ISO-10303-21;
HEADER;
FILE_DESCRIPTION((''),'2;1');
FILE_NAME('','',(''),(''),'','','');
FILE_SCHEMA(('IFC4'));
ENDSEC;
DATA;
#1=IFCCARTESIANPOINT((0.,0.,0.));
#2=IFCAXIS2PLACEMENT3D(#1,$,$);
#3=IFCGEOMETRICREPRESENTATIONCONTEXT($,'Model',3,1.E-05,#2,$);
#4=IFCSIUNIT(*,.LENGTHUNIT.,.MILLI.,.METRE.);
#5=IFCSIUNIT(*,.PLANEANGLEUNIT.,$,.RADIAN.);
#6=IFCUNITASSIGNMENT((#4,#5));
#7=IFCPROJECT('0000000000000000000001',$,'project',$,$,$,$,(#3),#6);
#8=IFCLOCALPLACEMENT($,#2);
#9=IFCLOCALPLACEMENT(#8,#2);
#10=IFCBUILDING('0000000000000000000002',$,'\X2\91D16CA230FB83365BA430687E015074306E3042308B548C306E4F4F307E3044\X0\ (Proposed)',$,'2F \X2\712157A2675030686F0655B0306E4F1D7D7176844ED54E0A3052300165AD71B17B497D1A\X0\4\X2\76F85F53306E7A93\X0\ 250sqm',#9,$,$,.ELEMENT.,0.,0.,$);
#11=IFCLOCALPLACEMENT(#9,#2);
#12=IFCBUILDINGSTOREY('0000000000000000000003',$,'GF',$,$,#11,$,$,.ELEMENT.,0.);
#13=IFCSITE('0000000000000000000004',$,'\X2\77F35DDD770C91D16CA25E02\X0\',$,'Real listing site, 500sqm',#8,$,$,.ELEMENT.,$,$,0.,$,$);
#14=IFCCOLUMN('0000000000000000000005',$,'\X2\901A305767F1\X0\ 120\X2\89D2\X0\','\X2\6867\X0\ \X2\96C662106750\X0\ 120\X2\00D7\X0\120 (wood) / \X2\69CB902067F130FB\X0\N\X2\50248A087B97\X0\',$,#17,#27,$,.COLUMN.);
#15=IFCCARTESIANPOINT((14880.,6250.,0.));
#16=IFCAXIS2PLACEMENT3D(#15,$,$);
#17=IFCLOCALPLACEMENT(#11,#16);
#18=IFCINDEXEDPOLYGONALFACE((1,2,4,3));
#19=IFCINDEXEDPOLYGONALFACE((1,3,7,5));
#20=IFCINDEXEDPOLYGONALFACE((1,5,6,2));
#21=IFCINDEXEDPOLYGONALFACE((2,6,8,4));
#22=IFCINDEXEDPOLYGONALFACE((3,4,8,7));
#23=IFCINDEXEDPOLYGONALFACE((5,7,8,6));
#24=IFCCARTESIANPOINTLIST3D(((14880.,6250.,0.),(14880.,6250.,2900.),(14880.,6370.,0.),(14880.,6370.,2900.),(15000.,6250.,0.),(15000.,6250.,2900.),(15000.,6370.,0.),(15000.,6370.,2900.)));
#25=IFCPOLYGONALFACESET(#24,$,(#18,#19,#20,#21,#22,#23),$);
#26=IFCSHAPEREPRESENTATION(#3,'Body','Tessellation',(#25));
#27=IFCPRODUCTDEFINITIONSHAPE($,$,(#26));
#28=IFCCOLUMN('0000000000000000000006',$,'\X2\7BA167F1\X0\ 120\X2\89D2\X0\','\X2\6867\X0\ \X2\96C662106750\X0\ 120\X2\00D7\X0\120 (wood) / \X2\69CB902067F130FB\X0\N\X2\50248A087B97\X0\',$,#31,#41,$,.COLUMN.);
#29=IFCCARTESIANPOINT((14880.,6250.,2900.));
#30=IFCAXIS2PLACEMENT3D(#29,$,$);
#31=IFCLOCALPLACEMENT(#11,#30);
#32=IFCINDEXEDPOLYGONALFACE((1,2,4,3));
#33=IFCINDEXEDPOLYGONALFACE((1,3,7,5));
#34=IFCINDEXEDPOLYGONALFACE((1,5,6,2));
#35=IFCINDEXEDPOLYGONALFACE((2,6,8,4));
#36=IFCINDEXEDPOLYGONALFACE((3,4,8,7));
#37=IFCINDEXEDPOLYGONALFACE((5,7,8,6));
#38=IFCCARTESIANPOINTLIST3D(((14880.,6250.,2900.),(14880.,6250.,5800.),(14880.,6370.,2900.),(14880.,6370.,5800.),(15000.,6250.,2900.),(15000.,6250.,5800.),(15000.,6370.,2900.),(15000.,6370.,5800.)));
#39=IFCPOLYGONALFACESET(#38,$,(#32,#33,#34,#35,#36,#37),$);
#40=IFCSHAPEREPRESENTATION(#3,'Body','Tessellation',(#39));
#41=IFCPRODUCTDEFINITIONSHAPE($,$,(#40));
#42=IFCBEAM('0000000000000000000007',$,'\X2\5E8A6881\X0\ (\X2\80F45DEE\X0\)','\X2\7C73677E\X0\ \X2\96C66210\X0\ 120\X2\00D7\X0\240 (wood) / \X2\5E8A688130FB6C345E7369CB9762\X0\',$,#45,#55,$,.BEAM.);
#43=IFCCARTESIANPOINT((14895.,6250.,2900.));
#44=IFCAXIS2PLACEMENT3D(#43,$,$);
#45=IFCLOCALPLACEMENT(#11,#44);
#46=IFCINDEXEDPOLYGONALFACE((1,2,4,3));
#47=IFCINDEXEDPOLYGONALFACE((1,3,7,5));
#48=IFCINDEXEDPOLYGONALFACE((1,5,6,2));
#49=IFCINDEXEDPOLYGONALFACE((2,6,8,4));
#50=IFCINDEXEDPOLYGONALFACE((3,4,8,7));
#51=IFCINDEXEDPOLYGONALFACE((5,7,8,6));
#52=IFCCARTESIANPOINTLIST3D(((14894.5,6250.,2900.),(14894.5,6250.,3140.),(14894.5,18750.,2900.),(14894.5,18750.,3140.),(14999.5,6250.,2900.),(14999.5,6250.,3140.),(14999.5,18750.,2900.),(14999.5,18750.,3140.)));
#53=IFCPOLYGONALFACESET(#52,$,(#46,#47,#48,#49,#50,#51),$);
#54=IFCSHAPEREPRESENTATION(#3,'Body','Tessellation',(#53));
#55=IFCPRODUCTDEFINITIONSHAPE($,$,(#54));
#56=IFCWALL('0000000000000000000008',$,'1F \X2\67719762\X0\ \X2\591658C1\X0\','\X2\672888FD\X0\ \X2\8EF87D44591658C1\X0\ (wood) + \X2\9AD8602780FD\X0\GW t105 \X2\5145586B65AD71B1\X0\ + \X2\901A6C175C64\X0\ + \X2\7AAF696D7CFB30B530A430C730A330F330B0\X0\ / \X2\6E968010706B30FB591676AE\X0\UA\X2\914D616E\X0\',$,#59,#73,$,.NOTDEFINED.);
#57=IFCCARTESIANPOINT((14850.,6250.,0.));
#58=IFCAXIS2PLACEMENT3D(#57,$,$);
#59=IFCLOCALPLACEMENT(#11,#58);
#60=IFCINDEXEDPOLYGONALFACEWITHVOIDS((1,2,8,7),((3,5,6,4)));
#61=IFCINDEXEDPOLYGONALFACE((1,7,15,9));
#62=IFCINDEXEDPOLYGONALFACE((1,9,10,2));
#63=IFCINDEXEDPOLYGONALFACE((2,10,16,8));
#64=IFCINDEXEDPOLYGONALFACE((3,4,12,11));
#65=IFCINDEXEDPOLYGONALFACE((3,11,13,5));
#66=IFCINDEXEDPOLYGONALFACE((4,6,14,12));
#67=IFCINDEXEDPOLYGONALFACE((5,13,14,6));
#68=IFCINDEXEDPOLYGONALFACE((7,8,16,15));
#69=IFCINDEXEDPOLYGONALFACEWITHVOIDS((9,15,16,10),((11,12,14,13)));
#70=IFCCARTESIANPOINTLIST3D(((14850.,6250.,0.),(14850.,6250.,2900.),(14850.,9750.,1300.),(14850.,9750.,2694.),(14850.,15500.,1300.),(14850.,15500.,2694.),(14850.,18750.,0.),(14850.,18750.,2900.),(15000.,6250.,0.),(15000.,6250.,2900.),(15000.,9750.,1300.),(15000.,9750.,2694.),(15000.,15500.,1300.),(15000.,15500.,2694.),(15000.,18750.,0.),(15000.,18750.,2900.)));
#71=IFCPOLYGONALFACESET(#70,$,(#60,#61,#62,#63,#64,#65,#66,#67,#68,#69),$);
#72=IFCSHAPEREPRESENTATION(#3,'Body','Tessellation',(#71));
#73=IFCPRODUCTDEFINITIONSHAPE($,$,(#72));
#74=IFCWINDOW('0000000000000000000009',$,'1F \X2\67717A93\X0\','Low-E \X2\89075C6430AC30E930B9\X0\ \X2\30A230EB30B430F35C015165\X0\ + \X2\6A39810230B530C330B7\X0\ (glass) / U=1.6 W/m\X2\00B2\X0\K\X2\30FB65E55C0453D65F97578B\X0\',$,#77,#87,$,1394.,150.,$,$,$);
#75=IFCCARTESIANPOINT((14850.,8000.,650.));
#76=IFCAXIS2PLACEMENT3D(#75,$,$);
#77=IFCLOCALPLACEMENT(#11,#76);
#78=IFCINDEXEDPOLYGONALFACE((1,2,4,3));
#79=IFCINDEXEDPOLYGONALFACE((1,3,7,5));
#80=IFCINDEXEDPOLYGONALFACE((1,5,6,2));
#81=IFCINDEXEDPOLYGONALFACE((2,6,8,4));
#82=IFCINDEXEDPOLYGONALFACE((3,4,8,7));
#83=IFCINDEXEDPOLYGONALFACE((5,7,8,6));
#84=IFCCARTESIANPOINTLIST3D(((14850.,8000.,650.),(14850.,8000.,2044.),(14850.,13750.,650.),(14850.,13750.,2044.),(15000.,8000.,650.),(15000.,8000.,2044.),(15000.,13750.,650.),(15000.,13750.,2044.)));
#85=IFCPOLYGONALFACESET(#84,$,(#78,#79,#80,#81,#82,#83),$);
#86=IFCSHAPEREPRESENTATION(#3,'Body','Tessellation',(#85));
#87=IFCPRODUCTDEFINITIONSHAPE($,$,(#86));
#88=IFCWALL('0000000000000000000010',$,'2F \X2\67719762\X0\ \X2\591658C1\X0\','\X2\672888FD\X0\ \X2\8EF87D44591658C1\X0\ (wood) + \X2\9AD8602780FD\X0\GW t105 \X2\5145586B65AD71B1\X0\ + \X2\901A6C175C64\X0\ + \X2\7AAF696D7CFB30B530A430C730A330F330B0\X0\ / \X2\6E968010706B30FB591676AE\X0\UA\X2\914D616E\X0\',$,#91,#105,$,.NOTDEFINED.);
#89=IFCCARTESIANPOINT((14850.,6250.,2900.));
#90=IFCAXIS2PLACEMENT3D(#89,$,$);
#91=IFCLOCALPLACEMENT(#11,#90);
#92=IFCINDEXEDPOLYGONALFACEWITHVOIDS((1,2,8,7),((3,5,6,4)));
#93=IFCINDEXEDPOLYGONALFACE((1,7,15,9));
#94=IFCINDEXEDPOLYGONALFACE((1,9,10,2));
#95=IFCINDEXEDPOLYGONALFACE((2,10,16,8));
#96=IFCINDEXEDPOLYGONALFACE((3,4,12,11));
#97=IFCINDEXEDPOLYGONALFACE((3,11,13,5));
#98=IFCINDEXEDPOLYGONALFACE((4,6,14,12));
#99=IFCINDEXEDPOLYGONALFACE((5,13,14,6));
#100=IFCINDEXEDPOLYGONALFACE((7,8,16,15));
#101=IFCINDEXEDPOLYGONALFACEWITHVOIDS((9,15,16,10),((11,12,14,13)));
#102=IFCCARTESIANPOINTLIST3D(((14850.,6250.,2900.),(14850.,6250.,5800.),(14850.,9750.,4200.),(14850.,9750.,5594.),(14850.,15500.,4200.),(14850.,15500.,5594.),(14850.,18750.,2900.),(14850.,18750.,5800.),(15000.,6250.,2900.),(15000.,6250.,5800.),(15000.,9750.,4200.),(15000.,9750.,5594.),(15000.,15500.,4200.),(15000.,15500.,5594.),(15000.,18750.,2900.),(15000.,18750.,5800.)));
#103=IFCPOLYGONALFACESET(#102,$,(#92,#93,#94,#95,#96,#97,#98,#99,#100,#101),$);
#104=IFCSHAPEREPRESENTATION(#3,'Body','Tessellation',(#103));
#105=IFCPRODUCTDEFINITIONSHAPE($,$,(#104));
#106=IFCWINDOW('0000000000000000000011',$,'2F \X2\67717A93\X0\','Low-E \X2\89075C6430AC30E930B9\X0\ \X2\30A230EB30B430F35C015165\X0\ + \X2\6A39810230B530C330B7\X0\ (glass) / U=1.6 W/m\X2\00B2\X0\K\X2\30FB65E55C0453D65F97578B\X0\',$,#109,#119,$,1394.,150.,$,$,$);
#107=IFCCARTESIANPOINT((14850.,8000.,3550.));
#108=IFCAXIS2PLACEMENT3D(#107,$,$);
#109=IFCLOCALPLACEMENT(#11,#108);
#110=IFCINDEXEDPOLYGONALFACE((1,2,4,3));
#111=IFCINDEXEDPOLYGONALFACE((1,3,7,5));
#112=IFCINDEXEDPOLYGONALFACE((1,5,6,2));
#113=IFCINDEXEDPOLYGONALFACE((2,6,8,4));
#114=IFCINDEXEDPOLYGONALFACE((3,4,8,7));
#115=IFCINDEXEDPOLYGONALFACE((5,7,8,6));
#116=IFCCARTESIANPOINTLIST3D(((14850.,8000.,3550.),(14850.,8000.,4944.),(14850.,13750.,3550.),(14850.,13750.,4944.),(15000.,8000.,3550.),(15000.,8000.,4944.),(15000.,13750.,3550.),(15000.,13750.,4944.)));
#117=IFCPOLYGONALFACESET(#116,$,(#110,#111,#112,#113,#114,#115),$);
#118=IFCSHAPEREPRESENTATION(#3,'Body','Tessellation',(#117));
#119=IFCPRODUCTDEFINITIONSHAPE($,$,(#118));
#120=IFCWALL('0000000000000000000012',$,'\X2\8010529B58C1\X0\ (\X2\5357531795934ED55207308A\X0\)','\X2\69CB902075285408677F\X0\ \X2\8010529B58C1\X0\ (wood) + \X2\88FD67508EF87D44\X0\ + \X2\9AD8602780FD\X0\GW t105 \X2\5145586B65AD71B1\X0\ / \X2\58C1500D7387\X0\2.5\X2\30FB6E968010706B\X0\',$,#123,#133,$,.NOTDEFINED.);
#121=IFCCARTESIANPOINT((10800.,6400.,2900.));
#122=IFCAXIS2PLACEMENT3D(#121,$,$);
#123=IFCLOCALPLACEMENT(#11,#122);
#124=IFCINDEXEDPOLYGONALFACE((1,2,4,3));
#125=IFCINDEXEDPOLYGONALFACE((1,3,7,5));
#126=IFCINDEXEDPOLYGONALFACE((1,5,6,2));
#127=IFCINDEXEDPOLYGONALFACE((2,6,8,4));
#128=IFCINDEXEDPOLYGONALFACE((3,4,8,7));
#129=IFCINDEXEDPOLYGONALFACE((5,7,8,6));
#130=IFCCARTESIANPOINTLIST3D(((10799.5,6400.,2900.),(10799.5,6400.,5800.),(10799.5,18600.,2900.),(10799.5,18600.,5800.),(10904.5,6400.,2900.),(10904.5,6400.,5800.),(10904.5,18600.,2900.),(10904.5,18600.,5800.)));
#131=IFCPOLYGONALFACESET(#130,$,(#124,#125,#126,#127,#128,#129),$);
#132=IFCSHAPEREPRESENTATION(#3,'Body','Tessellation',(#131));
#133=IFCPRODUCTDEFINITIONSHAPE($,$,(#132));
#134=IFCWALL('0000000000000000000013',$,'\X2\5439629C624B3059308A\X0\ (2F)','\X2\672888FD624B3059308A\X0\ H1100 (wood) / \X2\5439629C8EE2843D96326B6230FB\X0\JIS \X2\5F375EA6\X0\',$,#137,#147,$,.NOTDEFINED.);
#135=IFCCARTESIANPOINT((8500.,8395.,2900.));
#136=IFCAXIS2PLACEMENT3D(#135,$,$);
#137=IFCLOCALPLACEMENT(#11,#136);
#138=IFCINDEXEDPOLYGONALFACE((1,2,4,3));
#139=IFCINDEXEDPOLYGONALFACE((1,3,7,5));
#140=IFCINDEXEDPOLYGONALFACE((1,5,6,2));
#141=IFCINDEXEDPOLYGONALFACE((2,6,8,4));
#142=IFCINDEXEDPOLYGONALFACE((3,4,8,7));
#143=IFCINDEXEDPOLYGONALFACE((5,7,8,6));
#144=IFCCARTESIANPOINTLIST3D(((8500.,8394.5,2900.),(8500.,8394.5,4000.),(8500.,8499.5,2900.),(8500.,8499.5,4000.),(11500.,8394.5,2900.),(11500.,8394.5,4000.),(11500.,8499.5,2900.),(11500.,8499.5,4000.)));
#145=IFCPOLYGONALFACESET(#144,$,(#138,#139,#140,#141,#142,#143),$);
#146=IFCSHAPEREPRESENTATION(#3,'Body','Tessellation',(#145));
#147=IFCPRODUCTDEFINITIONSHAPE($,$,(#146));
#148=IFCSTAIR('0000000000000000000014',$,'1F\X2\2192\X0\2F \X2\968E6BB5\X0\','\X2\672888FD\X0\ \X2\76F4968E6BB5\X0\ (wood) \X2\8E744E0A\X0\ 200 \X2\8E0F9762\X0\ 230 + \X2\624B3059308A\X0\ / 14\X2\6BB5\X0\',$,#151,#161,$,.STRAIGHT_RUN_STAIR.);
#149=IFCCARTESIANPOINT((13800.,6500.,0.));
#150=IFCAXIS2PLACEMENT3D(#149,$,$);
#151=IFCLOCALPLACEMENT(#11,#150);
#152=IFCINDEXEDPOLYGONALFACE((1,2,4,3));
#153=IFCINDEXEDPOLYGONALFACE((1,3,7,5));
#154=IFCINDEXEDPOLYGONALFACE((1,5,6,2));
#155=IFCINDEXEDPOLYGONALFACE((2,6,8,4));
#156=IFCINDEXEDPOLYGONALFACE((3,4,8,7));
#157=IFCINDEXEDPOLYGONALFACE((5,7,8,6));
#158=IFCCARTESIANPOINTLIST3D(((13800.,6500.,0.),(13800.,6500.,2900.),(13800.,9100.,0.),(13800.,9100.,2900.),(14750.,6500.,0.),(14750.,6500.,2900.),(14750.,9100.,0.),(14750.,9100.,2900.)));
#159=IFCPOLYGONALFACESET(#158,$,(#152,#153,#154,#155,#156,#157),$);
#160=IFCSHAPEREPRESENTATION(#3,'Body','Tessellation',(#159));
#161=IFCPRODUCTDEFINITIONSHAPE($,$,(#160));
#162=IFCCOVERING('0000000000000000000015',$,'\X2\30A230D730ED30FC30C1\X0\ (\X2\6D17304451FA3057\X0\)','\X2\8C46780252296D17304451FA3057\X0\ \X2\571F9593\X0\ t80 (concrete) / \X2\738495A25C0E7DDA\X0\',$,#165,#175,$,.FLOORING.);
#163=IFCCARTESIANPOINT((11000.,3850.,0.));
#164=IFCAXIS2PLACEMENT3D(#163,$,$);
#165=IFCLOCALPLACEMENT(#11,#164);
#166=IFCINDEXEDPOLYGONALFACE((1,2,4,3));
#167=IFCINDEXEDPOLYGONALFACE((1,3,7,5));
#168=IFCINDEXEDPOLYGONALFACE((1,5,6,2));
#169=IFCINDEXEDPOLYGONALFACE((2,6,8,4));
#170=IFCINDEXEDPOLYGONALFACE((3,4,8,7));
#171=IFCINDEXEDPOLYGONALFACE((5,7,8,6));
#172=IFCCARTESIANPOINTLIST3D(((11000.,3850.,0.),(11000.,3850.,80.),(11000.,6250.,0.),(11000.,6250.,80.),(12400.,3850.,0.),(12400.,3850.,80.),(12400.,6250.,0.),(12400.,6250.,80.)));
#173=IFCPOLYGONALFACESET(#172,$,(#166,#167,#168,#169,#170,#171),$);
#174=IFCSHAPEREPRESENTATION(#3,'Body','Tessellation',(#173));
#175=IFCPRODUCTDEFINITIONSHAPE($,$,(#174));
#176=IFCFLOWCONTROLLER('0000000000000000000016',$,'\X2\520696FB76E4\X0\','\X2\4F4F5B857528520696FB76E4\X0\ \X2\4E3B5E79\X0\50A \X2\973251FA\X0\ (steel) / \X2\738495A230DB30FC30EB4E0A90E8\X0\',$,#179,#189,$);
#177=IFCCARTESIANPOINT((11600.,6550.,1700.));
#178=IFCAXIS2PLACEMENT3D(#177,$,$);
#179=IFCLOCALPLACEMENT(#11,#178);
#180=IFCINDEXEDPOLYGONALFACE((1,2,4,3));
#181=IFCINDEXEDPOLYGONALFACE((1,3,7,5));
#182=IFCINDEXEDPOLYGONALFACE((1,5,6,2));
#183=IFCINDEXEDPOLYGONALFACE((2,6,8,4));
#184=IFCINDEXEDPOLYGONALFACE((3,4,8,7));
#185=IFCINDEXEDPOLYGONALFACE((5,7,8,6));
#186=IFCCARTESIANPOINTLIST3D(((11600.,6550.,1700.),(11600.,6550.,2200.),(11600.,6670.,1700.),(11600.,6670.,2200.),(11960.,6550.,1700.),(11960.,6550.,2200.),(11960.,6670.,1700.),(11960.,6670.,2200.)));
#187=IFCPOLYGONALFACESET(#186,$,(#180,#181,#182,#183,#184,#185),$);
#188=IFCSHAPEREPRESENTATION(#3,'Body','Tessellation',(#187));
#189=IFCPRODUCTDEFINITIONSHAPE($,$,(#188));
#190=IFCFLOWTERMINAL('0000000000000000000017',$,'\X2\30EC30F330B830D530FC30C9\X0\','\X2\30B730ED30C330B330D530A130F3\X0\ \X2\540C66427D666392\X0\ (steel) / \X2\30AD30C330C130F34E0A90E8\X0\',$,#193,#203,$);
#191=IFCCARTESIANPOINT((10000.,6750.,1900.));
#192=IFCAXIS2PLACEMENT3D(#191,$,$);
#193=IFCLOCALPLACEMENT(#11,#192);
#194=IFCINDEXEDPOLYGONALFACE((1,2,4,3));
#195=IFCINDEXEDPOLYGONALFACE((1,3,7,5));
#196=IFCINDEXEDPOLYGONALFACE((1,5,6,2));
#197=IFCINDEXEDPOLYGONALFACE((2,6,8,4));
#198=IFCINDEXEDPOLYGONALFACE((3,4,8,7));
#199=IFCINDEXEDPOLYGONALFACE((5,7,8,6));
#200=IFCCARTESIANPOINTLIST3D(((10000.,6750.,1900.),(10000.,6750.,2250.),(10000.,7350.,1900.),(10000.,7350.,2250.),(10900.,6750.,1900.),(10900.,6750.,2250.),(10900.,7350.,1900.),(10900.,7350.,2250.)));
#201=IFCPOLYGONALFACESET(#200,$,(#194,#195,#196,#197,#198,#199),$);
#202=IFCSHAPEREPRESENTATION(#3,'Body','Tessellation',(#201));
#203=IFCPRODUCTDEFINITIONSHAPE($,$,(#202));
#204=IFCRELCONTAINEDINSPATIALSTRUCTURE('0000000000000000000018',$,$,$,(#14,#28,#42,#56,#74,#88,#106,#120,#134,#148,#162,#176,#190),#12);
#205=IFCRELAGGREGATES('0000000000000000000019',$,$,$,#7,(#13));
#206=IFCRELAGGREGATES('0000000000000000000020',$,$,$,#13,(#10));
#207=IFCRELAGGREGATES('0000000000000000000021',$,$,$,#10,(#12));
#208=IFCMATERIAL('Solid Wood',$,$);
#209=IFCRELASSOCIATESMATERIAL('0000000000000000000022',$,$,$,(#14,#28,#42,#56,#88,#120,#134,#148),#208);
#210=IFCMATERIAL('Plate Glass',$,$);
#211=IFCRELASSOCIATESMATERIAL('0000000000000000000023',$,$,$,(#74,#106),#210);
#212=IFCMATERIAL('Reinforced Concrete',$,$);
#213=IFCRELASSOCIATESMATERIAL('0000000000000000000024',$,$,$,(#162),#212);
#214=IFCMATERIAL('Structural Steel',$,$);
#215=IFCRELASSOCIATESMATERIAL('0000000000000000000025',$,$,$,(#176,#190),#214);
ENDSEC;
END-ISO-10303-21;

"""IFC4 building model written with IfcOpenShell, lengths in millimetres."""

from ifc_helpers import new_model, si_unit, frame, frame_2d, origin, place, context, project, spatial, rectangle, extrude, material, element, fill, save


model = new_model("IFC4")

# Units and contexts
model_context = context("Model", 3, precision=1e-05, world=origin())
ifc_project = project(units=[si_unit("LENGTHUNIT", "METRE", prefix="MILLI"), si_unit("PLANEANGLEUNIT", "RADIAN")], contexts=[model_context])

# Site, building, storey
site_placement = place(None, origin())
site = spatial("IfcSite", under=ifc_project, at=site_placement, Name="石川県金沢市", ObjectType="Real listing site, 500sqm", CompositionType="ELEMENT", RefElevation=0.0)
building_placement = place(site_placement, origin())
building = spatial("IfcBuilding", under=site, at=building_placement, Name="金沢・茶室と縁側のある和の住まい (Proposed)", ObjectType="2F 無垢材と漆喰の伝統的仕上げ、断熱等級4相当の窓 250sqm", CompositionType="ELEMENT", ElevationOfRefHeight=0.0, ElevationOfTerrain=0.0)
storey_placement = place(building_placement, origin())
storey = spatial("IfcBuildingStorey", under=building, at=storey_placement, Name="GF", CompositionType="ELEMENT", Elevation=0.0)

# Columns
ifc_material_1 = material(Name="Solid Wood")
column_1_placement = place(storey_placement, frame((14880.0, 6250.0, 0.0)))
element("IfcColumn", 1, at=column_1_placement, inside=storey, material=ifc_material_1, Name="通し柱 120角", Description="桧 集成材 120×120 (wood) / 構造柱・N値計算", PredefinedType="COLUMN", context=model_context, shape_type="SweptSolid", body=[
    extrude(rectangle(XDim=120.0, YDim=120.0, at=frame_2d((60.0, 60.0))), frame((14880.0, 6250.0, 0.0)), (0.0, 0.0, 1.0), 2900.0),
])
column_2_placement = place(storey_placement, frame((14880.0, 6250.0, 2900.0)))
element("IfcColumn", 2, at=column_2_placement, inside=storey, material=ifc_material_1, Name="管柱 120角", Description="桧 集成材 120×120 (wood) / 構造柱・N値計算", PredefinedType="COLUMN", context=model_context, shape_type="SweptSolid", body=[
    extrude(rectangle(XDim=120.0, YDim=120.0, at=frame_2d((60.0, 60.0))), frame((14880.0, 6250.0, 2900.0)), (0.0, 0.0, 1.0), 2900.0),
])

# Beam
beam_1_placement = place(storey_placement, frame((14895.0, 6250.0, 2900.0)))
element("IfcBeam", 3, at=beam_1_placement, inside=storey, material=ifc_material_1, Name="床梁 (胴差)", Description="米松 集成 120×240 (wood) / 床梁・水平構面", PredefinedType="BEAM", context=model_context, shape_type="SweptSolid", body=[
    extrude(rectangle(XDim=105.0, YDim=12500.0, at=frame_2d((52.0, 6250.0))), frame((14895.0, 6250.0, 2900.0)), (0.0, 0.0, 1.0), 240.0),
])

# Wall, opening, window
wall_1_placement = place(storey_placement, frame((14850.0, 6250.0, 0.0)))
wall_1 = element("IfcWall", 4, at=wall_1_placement, inside=storey, material=ifc_material_1, Name="1F 東面 外壁", Description="木製 軸組外壁 (wood) + 高性能GW t105 充填断熱 + 通気層 + 窯業系サイディング / 準耐火・外皮UA配慮", PredefinedType="NOTDEFINED", context=model_context, shape_type="SweptSolid", body=[
    extrude(rectangle(XDim=150.0, YDim=12500.0, at=frame_2d((75.0, 6250.0))), frame((14850.0, 6250.0, 0.0)), (0.0, 0.0, 1.0), 2900.0),
])
opening_1_placement = place(storey_placement, frame((14850.0, 8000.0, 650.0)))
opening_1 = element("IfcOpeningElement", 5, at=opening_1_placement, cuts=wall_1, PredefinedType="NOTDEFINED", context=model_context, shape_type="SweptSolid", body=[
    extrude(rectangle(XDim=150.0, YDim=5750.0, at=frame_2d((75.0, 2875.0))), frame((14850.0, 8000.0, 650.0)), (0.0, 0.0, 1.0), 1394.0),
])
ifc_material_2 = material(Name="Plate Glass")
window_1_placement = place(storey_placement, frame((14850.0, 8000.0, 650.0)))
window_1 = element("IfcWindow", 6, at=window_1_placement, inside=storey, material=ifc_material_2, Name="1F 東窓", Description="Low-E 複層ガラス アルゴン封入 + 樹脂サッシ (glass) / U=1.6 W/m²K・日射取得型", OverallHeight=1394.0, OverallWidth=150.0, context=model_context, shape_type="SweptSolid", body=[
    extrude(rectangle(XDim=150.0, YDim=5750.0, at=frame_2d((75.0, 2875.0))), frame((14850.0, 8000.0, 650.0)), (0.0, 0.0, 1.0), 1394.0),
])
fill(opening_1, window_1)

# Wall, opening, window
wall_2_placement = place(storey_placement, frame((14850.0, 6250.0, 2900.0)))
wall_2 = element("IfcWall", 7, at=wall_2_placement, inside=storey, material=ifc_material_1, Name="2F 東面 外壁", Description="木製 軸組外壁 (wood) + 高性能GW t105 充填断熱 + 通気層 + 窯業系サイディング / 準耐火・外皮UA配慮", PredefinedType="NOTDEFINED", context=model_context, shape_type="SweptSolid", body=[
    extrude(rectangle(XDim=150.0, YDim=12500.0, at=frame_2d((75.0, 6250.0))), frame((14850.0, 6250.0, 2900.0)), (0.0, 0.0, 1.0), 2900.0),
])
opening_2_placement = place(storey_placement, frame((14850.0, 8000.0, 3550.0)))
opening_2 = element("IfcOpeningElement", 8, at=opening_2_placement, cuts=wall_2, PredefinedType="NOTDEFINED", context=model_context, shape_type="SweptSolid", body=[
    extrude(rectangle(XDim=150.0, YDim=5750.0, at=frame_2d((75.0, 2875.0))), frame((14850.0, 8000.0, 3550.0)), (0.0, 0.0, 1.0), 1394.0),
])
window_2_placement = place(storey_placement, frame((14850.0, 8000.0, 3550.0)))
window_2 = element("IfcWindow", 9, at=window_2_placement, inside=storey, material=ifc_material_2, Name="2F 東窓", Description="Low-E 複層ガラス アルゴン封入 + 樹脂サッシ (glass) / U=1.6 W/m²K・日射取得型", OverallHeight=1394.0, OverallWidth=150.0, context=model_context, shape_type="SweptSolid", body=[
    extrude(rectangle(XDim=150.0, YDim=5750.0, at=frame_2d((75.0, 2875.0))), frame((14850.0, 8000.0, 3550.0)), (0.0, 0.0, 1.0), 1394.0),
])
fill(opening_2, window_2)

# Walls
wall_3_placement = place(storey_placement, frame((10800.0, 6400.0, 2900.0)))
element("IfcWall", 10, at=wall_3_placement, inside=storey, material=ifc_material_1, Name="耐力壁 (南北間仕切り)", Description="構造用合板 耐力壁 (wood) + 製材軸組 + 高性能GW t105 充填断熱 / 壁倍率2.5・準耐火", PredefinedType="NOTDEFINED", context=model_context, shape_type="SweptSolid", body=[
    extrude(rectangle(XDim=105.0, YDim=12200.0, at=frame_2d((52.0, 6100.0))), frame((10800.0, 6400.0, 2900.0)), (0.0, 0.0, 1.0), 2900.0),
])
wall_4_placement = place(storey_placement, frame((8500.0, 8395.0, 2900.0)))
element("IfcWall", 11, at=wall_4_placement, inside=storey, material=ifc_material_1, Name="吹抜手すり (2F)", Description="木製手すり H1100 (wood) / 吹抜転落防止・JIS 強度", PredefinedType="NOTDEFINED", context=model_context, shape_type="SweptSolid", body=[
    extrude(rectangle(XDim=3000.0, YDim=105.0, at=frame_2d((1500.0, 52.0))), frame((8500.0, 8395.0, 2900.0)), (0.0, 0.0, 1.0), 1100.0),
])

# Stair
stair_placement = place(storey_placement, frame((13800.0, 6500.0, 0.0)))
element("IfcStair", 12, at=stair_placement, inside=storey, material=ifc_material_1, Name="1F→2F 階段", Description="木製 直階段 (wood) 蹴上 200 踏面 230 + 手すり / 14段", PredefinedType="STRAIGHT_RUN_STAIR", context=model_context, shape_type="SweptSolid", body=[
    extrude(rectangle(XDim=950.0, YDim=2600.0, at=frame_2d((475.0, 1300.0))), frame((13800.0, 6500.0, 0.0)), (0.0, 0.0, 1.0), 2900.0),
])

# Covering
ifc_material_3 = material(Name="Reinforced Concrete")
covering_placement = place(storey_placement, frame((11000.0, 3850.0, 0.0)))
element("IfcCovering", 13, at=covering_placement, inside=storey, material=ifc_material_3, Name="アプローチ (洗い出し)", Description="豆砂利洗い出し 土間 t80 (concrete) / 玄関導線", PredefinedType="FLOORING", context=model_context, shape_type="SweptSolid", body=[
    extrude(rectangle(XDim=1400.0, YDim=2400.0, at=frame_2d((700.0, 1200.0))), frame((11000.0, 3850.0, 0.0)), (0.0, 0.0, 1.0), 80.0),
])

# Flow controller
ifc_material_4 = material(Name="Structural Steel")
flow_controller_placement = place(storey_placement, frame((11600.0, 6550.0, 1700.0)))
element("IfcFlowController", 14, at=flow_controller_placement, inside=storey, material=ifc_material_4, Name="分電盤", Description="住宅用分電盤 主幹50A 露出 (steel) / 玄関ホール上部", context=model_context, shape_type="SweptSolid", body=[
    extrude(rectangle(XDim=360.0, YDim=120.0, at=frame_2d((180.0, 60.0))), frame((11600.0, 6550.0, 1700.0)), (0.0, 0.0, 1.0), 500.0),
])

# Flow terminal
flow_terminal_1_placement = place(storey_placement, frame((10000.0, 6750.0, 1900.0)))
element("IfcFlowTerminal", 15, at=flow_terminal_1_placement, inside=storey, material=ifc_material_4, Name="レンジフード", Description="シロッコファン 同時給排 (steel) / キッチン上部", context=model_context, shape_type="SweptSolid", body=[
    extrude(rectangle(XDim=900.0, YDim=600.0, at=frame_2d((450.0, 300.0))), frame((10000.0, 6750.0, 1900.0)), (0.0, 0.0, 1.0), 350.0),
])

save(model, "model.ifc")
